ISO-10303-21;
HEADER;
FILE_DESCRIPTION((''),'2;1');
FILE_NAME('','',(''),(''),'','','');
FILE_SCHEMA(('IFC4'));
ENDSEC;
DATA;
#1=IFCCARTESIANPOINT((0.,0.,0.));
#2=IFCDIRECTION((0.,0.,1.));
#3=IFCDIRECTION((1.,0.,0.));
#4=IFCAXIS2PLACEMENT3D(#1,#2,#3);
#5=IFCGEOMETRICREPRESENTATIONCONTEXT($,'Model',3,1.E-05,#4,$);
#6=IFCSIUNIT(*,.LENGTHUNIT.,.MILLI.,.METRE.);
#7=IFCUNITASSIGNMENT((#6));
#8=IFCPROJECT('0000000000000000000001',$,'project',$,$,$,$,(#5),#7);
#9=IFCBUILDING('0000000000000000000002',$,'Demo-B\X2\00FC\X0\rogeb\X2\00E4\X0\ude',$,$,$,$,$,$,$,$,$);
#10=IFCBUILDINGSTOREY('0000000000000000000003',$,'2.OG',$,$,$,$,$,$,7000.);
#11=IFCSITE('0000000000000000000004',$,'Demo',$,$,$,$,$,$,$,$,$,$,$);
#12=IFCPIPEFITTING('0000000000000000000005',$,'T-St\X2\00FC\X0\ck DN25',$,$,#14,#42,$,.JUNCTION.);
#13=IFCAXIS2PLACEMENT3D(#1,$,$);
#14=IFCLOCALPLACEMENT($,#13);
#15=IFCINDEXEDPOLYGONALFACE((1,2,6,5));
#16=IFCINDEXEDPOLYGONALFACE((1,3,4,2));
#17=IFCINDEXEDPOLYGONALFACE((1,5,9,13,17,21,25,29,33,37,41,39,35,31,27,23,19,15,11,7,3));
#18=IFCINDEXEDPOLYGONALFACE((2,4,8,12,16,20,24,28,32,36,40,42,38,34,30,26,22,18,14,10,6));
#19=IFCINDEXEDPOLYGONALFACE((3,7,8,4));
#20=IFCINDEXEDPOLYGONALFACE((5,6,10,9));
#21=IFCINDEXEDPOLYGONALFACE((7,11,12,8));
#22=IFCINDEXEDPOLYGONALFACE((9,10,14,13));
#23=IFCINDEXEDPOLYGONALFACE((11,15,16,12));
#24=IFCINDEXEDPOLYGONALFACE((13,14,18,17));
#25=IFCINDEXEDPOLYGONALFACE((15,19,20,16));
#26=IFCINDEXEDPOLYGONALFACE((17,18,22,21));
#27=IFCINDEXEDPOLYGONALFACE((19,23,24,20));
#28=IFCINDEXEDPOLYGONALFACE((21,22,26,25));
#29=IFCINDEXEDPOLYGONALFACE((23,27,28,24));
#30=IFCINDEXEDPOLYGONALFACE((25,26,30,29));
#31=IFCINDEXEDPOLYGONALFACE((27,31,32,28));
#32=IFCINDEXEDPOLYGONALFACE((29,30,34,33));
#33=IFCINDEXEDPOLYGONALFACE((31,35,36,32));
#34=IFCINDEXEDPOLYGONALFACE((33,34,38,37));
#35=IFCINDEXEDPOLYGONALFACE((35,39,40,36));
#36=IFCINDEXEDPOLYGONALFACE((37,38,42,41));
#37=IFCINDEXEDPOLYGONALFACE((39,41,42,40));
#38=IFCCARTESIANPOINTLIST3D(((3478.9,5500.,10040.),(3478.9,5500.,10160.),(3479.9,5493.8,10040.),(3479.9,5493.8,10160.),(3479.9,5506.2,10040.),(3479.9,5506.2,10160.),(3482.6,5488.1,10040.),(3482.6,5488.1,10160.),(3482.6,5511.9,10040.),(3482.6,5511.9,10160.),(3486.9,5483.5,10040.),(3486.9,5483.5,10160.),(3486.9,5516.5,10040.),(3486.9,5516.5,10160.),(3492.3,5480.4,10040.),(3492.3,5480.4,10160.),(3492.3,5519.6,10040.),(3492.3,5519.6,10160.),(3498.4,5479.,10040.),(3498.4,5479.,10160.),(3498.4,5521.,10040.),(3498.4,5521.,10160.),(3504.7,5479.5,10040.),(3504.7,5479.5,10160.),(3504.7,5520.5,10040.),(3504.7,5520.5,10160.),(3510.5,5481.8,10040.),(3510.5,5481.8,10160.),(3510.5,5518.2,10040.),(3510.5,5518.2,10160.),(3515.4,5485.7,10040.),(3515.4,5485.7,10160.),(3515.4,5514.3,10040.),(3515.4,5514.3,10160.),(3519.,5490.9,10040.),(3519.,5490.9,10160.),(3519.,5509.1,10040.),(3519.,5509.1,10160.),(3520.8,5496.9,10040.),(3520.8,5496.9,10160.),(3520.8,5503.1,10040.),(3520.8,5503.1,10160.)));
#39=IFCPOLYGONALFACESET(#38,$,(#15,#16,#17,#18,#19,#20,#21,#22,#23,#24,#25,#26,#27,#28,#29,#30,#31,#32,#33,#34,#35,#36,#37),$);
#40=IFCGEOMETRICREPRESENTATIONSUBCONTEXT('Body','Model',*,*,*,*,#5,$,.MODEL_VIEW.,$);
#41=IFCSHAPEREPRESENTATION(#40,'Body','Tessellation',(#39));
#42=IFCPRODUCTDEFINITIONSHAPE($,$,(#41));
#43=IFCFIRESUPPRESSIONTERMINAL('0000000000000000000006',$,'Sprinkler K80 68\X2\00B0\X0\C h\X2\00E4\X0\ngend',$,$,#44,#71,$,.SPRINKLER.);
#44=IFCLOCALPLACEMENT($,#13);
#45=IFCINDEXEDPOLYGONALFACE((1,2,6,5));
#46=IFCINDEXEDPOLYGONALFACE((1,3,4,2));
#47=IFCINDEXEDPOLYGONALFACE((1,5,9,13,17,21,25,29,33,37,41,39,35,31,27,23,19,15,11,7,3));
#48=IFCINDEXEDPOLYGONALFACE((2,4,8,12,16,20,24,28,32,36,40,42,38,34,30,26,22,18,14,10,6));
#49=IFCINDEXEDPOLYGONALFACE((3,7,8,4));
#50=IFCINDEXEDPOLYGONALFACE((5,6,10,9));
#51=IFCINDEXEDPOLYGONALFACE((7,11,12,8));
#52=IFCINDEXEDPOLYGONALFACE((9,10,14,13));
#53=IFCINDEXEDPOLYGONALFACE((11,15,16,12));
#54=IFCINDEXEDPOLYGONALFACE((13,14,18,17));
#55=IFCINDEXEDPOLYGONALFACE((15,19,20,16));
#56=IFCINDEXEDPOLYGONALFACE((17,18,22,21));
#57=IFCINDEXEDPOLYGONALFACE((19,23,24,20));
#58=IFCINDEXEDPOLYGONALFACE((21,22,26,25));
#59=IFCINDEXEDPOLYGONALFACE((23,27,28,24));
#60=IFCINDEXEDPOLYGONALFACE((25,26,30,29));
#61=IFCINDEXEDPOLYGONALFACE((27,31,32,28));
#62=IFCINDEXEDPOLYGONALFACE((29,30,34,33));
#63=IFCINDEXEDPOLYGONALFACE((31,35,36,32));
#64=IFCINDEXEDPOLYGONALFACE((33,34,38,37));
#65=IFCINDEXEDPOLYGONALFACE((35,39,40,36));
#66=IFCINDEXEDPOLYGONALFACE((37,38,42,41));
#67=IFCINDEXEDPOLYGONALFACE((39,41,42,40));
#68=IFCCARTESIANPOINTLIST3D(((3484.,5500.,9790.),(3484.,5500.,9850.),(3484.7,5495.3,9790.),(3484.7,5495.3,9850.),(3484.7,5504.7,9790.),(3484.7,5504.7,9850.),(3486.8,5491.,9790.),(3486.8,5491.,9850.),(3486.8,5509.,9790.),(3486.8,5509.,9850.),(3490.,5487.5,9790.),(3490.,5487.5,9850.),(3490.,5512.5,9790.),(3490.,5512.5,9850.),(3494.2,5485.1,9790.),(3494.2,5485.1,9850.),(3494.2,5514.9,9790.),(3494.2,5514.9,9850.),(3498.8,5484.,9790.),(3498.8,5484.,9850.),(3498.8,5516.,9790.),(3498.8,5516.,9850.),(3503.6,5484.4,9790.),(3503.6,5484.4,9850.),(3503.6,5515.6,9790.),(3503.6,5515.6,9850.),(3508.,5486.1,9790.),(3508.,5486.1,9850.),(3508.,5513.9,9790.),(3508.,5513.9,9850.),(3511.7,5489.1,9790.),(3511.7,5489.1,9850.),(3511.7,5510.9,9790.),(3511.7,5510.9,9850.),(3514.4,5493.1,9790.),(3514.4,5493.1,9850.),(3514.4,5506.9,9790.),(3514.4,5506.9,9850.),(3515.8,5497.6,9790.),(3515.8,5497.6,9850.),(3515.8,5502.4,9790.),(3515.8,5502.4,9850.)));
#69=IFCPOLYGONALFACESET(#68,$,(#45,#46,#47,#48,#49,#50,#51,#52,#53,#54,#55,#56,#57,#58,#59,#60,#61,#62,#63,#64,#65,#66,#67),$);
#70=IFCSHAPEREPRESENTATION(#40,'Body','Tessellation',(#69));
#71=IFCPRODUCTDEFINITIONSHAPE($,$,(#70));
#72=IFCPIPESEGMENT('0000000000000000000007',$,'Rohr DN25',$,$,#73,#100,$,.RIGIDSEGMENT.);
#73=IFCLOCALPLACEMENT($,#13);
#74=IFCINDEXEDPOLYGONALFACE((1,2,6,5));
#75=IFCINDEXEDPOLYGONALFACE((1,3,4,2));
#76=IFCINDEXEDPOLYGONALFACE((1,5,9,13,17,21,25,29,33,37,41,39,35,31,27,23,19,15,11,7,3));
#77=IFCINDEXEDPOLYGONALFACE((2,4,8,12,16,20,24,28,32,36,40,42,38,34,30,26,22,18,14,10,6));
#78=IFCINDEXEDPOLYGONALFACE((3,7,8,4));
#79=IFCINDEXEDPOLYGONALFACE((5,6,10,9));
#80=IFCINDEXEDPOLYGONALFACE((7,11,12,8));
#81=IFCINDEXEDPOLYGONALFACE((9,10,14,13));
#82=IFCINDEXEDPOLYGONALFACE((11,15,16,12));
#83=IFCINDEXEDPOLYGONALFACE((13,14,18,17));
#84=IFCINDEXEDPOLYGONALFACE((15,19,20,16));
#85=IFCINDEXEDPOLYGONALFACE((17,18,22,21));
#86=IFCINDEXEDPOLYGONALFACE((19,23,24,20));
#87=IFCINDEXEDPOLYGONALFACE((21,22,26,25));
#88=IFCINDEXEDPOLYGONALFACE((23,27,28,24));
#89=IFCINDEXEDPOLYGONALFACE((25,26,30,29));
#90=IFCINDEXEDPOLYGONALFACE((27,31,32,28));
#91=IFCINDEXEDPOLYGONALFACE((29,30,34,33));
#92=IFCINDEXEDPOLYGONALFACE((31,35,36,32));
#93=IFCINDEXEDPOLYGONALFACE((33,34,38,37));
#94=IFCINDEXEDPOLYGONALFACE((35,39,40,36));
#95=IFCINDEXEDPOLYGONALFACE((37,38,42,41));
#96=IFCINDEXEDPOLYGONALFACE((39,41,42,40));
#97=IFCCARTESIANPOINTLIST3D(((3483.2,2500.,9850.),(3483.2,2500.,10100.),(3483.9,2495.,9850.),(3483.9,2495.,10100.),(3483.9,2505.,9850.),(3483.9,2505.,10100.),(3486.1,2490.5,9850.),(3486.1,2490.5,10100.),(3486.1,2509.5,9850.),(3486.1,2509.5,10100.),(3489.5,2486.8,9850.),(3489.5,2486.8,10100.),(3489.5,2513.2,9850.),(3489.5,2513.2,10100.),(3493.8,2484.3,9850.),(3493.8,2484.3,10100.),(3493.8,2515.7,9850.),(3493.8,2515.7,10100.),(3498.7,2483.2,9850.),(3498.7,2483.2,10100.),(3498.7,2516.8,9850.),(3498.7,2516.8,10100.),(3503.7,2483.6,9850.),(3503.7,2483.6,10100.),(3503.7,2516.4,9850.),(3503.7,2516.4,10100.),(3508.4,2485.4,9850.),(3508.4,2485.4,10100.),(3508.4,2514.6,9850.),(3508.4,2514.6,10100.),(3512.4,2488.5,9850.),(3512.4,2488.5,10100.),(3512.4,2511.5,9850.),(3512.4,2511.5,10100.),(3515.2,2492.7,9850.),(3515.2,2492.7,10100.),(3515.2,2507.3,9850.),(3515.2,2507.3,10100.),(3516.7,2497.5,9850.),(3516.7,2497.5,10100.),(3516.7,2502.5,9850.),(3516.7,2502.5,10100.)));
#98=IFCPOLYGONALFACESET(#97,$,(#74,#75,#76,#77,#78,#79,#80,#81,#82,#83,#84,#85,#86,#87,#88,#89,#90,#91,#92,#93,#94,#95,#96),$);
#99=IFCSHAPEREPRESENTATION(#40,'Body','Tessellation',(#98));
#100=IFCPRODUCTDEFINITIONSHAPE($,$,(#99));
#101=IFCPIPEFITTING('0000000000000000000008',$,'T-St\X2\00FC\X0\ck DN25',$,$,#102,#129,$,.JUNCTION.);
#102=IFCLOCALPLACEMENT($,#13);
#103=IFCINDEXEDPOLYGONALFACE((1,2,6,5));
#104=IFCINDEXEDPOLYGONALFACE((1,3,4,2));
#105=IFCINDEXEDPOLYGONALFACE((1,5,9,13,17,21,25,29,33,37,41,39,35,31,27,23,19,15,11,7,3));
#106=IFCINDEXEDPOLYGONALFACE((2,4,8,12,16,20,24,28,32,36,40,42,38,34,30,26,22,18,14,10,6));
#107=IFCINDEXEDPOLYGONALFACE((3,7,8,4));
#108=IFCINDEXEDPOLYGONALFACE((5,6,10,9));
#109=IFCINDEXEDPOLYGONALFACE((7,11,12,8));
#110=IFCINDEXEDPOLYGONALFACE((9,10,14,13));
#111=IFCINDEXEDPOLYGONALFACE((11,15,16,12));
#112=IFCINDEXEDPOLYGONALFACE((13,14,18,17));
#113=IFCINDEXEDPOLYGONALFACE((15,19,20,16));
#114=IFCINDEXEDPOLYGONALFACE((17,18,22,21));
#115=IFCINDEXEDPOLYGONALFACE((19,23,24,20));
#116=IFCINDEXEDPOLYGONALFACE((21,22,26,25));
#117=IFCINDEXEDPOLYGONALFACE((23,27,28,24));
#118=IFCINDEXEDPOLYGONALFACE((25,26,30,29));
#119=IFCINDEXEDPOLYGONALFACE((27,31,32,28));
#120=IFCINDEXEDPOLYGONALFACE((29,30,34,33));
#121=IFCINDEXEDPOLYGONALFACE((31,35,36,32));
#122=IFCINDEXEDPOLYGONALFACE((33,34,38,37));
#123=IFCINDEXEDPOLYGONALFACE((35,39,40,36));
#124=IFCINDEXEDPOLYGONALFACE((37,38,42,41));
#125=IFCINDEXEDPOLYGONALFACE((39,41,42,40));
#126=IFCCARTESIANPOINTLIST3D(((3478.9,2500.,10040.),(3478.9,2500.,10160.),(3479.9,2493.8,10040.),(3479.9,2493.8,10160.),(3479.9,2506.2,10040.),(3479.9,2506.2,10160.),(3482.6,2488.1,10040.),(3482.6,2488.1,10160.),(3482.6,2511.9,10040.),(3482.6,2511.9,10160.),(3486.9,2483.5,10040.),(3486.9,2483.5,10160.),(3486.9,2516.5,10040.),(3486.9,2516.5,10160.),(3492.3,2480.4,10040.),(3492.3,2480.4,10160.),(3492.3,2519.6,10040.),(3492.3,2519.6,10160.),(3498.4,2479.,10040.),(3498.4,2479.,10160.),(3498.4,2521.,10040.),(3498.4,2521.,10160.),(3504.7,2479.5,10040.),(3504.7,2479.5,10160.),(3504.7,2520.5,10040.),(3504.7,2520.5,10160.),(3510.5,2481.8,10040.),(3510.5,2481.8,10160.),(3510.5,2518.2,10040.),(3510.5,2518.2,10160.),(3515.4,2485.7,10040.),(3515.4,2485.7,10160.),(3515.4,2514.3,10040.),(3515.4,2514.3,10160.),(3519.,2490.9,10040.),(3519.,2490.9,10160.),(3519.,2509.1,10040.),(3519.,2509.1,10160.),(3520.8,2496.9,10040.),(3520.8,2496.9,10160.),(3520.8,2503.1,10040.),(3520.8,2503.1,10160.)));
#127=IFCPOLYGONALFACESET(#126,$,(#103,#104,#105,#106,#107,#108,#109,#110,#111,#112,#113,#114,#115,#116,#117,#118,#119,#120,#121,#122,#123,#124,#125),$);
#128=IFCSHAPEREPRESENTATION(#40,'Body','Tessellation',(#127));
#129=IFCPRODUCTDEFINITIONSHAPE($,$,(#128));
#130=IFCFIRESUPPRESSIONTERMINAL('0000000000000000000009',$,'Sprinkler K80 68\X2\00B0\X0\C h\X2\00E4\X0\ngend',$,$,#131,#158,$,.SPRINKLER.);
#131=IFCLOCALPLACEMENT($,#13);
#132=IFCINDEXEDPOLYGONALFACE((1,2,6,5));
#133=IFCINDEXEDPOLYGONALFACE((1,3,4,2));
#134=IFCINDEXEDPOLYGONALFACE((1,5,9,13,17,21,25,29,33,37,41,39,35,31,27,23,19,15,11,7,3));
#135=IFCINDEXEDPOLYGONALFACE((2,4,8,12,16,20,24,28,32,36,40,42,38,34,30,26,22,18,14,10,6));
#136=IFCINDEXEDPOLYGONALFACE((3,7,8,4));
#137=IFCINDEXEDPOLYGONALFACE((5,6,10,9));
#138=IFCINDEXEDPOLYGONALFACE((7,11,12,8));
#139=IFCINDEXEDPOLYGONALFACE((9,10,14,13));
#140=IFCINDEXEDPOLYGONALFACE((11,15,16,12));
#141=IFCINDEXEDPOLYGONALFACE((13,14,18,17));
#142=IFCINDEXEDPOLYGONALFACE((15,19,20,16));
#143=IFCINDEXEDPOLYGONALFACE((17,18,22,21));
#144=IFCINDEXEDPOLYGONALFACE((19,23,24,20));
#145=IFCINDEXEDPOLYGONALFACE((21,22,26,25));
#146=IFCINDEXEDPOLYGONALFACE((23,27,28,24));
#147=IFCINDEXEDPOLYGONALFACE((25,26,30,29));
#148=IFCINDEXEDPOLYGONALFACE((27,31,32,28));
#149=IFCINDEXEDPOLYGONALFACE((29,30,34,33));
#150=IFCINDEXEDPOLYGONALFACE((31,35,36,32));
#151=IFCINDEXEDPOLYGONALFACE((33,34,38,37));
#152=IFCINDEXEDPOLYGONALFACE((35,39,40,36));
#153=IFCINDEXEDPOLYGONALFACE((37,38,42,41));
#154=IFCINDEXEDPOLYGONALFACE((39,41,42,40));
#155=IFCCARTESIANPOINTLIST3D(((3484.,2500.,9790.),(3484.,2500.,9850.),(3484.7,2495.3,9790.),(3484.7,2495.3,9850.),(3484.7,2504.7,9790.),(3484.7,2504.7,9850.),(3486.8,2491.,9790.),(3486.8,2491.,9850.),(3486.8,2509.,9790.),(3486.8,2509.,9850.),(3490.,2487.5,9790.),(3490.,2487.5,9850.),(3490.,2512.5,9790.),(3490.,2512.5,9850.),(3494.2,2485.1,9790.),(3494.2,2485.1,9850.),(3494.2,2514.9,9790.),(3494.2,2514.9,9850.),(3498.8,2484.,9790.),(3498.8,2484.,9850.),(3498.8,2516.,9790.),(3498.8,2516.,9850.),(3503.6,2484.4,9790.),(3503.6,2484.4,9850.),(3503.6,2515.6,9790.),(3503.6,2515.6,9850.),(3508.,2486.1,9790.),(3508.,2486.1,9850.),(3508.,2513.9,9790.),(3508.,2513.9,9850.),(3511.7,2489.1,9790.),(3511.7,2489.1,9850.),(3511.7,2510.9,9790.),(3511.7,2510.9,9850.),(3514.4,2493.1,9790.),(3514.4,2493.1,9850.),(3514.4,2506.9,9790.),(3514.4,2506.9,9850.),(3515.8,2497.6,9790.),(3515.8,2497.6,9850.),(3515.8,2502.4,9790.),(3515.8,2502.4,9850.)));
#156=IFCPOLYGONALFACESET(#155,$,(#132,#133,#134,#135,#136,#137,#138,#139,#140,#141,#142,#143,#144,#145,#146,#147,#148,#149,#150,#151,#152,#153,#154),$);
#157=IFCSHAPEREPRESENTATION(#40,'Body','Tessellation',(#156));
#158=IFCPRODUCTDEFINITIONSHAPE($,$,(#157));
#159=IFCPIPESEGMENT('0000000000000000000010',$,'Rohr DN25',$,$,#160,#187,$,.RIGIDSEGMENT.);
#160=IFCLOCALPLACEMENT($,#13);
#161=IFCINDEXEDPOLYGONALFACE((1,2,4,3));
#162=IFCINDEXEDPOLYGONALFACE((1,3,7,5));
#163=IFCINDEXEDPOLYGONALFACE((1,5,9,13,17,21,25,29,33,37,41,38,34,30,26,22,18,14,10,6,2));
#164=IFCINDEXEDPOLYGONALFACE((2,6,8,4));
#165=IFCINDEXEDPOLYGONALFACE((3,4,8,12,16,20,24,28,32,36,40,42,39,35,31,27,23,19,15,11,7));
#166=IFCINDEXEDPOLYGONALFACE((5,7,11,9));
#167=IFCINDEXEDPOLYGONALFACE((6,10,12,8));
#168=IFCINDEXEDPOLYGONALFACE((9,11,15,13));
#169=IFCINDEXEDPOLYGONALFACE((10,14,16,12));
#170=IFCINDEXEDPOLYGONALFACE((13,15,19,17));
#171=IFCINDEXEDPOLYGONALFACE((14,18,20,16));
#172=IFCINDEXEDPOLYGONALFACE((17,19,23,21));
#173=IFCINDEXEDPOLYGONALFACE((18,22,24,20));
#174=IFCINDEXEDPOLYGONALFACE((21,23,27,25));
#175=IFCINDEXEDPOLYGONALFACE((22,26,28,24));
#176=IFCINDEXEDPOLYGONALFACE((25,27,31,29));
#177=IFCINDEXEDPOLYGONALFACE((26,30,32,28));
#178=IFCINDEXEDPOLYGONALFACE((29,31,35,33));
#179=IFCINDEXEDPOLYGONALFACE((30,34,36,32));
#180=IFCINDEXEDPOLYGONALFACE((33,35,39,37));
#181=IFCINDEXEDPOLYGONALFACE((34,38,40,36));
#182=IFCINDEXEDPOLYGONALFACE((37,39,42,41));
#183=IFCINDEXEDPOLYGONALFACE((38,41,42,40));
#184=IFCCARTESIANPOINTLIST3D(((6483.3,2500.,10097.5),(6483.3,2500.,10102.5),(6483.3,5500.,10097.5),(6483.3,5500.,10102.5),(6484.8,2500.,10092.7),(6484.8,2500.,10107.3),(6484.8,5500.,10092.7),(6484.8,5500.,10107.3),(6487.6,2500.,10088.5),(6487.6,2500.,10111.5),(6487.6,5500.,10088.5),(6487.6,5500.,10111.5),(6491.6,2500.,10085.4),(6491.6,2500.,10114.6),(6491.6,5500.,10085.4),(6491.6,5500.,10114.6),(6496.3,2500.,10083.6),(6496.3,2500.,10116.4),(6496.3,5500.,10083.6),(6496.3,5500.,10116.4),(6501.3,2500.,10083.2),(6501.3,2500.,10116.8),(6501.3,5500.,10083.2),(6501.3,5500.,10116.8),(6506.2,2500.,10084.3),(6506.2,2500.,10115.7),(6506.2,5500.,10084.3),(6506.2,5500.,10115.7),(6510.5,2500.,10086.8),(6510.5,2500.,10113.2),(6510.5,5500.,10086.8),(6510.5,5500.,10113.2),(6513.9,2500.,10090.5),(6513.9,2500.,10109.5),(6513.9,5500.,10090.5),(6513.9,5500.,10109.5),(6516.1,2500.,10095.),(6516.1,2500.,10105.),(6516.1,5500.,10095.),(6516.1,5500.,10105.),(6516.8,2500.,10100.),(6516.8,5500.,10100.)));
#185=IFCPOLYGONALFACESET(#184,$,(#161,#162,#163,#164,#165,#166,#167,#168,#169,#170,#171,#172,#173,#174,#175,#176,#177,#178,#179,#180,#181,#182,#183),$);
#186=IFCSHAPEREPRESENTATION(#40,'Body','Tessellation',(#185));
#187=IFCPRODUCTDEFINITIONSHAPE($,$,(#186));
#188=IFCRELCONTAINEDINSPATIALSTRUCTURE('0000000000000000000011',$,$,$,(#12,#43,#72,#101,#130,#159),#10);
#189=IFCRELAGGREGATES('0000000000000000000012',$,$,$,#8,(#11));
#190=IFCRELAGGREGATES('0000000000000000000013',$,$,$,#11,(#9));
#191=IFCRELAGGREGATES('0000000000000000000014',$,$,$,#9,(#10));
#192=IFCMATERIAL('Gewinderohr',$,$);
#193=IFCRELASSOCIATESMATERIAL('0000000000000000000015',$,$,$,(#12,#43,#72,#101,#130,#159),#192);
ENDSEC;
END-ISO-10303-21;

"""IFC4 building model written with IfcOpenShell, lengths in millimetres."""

from ifc_helpers import new_model, si_unit, frame, origin_with_axes, place, context, subcontext, project, spatial, circle, extrude, material, element, save


model = new_model("IFC4")

# Units and contexts
model_context = context("Model", 3, precision=1e-05, world=origin_with_axes())
body_context = subcontext(model_context, "Body", "Model", "MODEL_VIEW")
ifc_project = project(units=[si_unit("LENGTHUNIT", "METRE", prefix="MILLI")], contexts=[model_context])

# Site, building, storey
site = spatial("IfcSite", under=ifc_project, Name="Demo")
building = spatial("IfcBuilding", under=site, Name="Demo-Bürogebäude")
storey = spatial("IfcBuildingStorey", under=building, Name="2.OG", Elevation=7000.0)

# Shared definitions
ifc_material_1 = material(Name="Gewinderohr")

# Pipe fitting
pipe_fitting_1_placement = place(None, frame((3500.0, 5500.0, 10160.0), z_axis=(0.0, 0.0, -1.0), x_axis=(-1.0, 0.0, 0.0)))
element("IfcPipeFitting", 1, at=pipe_fitting_1_placement, inside=storey, material=ifc_material_1, Name="T-Stück DN25", PredefinedType="JUNCTION", context=body_context, shape_type="SweptSolid", body=[
    extrude(circle(Radius=21.1), origin_with_axes(), (0.0, 0.0, 1.0), 120.0),
])

# Fire suppression terminal
fire_suppression_terminal_1_placement = place(None, frame((3500.0, 5500.0, 9850.0), z_axis=(0.0, 0.0, -1.0), x_axis=(-1.0, 0.0, 0.0)))
element("IfcFireSuppressionTerminal", 2, at=fire_suppression_terminal_1_placement, inside=storey, material=ifc_material_1, Name="Sprinkler K80 68°C hängend", PredefinedType="SPRINKLER", context=body_context, shape_type="SweptSolid", body=[
    extrude(circle(Radius=16.0), origin_with_axes(), (0.0, 0.0, 1.0), 60.0),
])

# Pipe segment
pipe_segment_1_placement = place(None, frame((3500.0, 2500.0, 10100.0), z_axis=(0.0, 0.0, -1.0), x_axis=(-1.0, 0.0, 0.0)))
element("IfcPipeSegment", 3, at=pipe_segment_1_placement, inside=storey, material=ifc_material_1, Name="Rohr DN25", PredefinedType="RIGIDSEGMENT", context=body_context, shape_type="SweptSolid", body=[
    extrude(circle(Radius=16.9), origin_with_axes(), (0.0, 0.0, 1.0), 250.0),
])

# Pipe fitting
pipe_fitting_2_placement = place(None, frame((3500.0, 2500.0, 10160.0), z_axis=(0.0, 0.0, -1.0), x_axis=(-1.0, 0.0, 0.0)))
element("IfcPipeFitting", 4, at=pipe_fitting_2_placement, inside=storey, material=ifc_material_1, Name="T-Stück DN25", PredefinedType="JUNCTION", context=body_context, shape_type="SweptSolid", body=[
    extrude(circle(Radius=21.1), origin_with_axes(), (0.0, 0.0, 1.0), 120.0),
])

# Fire suppression terminal
fire_suppression_terminal_2_placement = place(None, frame((3500.0, 2500.0, 9850.0), z_axis=(0.0, 0.0, -1.0), x_axis=(-1.0, 0.0, 0.0)))
element("IfcFireSuppressionTerminal", 5, at=fire_suppression_terminal_2_placement, inside=storey, material=ifc_material_1, Name="Sprinkler K80 68°C hängend", PredefinedType="SPRINKLER", context=body_context, shape_type="SweptSolid", body=[
    extrude(circle(Radius=16.0), origin_with_axes(), (0.0, 0.0, 1.0), 60.0),
])

# Pipe segment
pipe_segment_2_placement = place(None, frame((6500.0, 5500.0, 10100.0), z_axis=(0.0, -1.0, 0.0), x_axis=(1.0, 0.0, 0.0)))
element("IfcPipeSegment", 6, at=pipe_segment_2_placement, inside=storey, material=ifc_material_1, Name="Rohr DN25", PredefinedType="RIGIDSEGMENT", context=body_context, shape_type="SweptSolid", body=[
    extrude(circle(Radius=16.9), origin_with_axes(), (0.0, 0.0, 1.0), 3000.0),
])

save(model, "model.ifc")
